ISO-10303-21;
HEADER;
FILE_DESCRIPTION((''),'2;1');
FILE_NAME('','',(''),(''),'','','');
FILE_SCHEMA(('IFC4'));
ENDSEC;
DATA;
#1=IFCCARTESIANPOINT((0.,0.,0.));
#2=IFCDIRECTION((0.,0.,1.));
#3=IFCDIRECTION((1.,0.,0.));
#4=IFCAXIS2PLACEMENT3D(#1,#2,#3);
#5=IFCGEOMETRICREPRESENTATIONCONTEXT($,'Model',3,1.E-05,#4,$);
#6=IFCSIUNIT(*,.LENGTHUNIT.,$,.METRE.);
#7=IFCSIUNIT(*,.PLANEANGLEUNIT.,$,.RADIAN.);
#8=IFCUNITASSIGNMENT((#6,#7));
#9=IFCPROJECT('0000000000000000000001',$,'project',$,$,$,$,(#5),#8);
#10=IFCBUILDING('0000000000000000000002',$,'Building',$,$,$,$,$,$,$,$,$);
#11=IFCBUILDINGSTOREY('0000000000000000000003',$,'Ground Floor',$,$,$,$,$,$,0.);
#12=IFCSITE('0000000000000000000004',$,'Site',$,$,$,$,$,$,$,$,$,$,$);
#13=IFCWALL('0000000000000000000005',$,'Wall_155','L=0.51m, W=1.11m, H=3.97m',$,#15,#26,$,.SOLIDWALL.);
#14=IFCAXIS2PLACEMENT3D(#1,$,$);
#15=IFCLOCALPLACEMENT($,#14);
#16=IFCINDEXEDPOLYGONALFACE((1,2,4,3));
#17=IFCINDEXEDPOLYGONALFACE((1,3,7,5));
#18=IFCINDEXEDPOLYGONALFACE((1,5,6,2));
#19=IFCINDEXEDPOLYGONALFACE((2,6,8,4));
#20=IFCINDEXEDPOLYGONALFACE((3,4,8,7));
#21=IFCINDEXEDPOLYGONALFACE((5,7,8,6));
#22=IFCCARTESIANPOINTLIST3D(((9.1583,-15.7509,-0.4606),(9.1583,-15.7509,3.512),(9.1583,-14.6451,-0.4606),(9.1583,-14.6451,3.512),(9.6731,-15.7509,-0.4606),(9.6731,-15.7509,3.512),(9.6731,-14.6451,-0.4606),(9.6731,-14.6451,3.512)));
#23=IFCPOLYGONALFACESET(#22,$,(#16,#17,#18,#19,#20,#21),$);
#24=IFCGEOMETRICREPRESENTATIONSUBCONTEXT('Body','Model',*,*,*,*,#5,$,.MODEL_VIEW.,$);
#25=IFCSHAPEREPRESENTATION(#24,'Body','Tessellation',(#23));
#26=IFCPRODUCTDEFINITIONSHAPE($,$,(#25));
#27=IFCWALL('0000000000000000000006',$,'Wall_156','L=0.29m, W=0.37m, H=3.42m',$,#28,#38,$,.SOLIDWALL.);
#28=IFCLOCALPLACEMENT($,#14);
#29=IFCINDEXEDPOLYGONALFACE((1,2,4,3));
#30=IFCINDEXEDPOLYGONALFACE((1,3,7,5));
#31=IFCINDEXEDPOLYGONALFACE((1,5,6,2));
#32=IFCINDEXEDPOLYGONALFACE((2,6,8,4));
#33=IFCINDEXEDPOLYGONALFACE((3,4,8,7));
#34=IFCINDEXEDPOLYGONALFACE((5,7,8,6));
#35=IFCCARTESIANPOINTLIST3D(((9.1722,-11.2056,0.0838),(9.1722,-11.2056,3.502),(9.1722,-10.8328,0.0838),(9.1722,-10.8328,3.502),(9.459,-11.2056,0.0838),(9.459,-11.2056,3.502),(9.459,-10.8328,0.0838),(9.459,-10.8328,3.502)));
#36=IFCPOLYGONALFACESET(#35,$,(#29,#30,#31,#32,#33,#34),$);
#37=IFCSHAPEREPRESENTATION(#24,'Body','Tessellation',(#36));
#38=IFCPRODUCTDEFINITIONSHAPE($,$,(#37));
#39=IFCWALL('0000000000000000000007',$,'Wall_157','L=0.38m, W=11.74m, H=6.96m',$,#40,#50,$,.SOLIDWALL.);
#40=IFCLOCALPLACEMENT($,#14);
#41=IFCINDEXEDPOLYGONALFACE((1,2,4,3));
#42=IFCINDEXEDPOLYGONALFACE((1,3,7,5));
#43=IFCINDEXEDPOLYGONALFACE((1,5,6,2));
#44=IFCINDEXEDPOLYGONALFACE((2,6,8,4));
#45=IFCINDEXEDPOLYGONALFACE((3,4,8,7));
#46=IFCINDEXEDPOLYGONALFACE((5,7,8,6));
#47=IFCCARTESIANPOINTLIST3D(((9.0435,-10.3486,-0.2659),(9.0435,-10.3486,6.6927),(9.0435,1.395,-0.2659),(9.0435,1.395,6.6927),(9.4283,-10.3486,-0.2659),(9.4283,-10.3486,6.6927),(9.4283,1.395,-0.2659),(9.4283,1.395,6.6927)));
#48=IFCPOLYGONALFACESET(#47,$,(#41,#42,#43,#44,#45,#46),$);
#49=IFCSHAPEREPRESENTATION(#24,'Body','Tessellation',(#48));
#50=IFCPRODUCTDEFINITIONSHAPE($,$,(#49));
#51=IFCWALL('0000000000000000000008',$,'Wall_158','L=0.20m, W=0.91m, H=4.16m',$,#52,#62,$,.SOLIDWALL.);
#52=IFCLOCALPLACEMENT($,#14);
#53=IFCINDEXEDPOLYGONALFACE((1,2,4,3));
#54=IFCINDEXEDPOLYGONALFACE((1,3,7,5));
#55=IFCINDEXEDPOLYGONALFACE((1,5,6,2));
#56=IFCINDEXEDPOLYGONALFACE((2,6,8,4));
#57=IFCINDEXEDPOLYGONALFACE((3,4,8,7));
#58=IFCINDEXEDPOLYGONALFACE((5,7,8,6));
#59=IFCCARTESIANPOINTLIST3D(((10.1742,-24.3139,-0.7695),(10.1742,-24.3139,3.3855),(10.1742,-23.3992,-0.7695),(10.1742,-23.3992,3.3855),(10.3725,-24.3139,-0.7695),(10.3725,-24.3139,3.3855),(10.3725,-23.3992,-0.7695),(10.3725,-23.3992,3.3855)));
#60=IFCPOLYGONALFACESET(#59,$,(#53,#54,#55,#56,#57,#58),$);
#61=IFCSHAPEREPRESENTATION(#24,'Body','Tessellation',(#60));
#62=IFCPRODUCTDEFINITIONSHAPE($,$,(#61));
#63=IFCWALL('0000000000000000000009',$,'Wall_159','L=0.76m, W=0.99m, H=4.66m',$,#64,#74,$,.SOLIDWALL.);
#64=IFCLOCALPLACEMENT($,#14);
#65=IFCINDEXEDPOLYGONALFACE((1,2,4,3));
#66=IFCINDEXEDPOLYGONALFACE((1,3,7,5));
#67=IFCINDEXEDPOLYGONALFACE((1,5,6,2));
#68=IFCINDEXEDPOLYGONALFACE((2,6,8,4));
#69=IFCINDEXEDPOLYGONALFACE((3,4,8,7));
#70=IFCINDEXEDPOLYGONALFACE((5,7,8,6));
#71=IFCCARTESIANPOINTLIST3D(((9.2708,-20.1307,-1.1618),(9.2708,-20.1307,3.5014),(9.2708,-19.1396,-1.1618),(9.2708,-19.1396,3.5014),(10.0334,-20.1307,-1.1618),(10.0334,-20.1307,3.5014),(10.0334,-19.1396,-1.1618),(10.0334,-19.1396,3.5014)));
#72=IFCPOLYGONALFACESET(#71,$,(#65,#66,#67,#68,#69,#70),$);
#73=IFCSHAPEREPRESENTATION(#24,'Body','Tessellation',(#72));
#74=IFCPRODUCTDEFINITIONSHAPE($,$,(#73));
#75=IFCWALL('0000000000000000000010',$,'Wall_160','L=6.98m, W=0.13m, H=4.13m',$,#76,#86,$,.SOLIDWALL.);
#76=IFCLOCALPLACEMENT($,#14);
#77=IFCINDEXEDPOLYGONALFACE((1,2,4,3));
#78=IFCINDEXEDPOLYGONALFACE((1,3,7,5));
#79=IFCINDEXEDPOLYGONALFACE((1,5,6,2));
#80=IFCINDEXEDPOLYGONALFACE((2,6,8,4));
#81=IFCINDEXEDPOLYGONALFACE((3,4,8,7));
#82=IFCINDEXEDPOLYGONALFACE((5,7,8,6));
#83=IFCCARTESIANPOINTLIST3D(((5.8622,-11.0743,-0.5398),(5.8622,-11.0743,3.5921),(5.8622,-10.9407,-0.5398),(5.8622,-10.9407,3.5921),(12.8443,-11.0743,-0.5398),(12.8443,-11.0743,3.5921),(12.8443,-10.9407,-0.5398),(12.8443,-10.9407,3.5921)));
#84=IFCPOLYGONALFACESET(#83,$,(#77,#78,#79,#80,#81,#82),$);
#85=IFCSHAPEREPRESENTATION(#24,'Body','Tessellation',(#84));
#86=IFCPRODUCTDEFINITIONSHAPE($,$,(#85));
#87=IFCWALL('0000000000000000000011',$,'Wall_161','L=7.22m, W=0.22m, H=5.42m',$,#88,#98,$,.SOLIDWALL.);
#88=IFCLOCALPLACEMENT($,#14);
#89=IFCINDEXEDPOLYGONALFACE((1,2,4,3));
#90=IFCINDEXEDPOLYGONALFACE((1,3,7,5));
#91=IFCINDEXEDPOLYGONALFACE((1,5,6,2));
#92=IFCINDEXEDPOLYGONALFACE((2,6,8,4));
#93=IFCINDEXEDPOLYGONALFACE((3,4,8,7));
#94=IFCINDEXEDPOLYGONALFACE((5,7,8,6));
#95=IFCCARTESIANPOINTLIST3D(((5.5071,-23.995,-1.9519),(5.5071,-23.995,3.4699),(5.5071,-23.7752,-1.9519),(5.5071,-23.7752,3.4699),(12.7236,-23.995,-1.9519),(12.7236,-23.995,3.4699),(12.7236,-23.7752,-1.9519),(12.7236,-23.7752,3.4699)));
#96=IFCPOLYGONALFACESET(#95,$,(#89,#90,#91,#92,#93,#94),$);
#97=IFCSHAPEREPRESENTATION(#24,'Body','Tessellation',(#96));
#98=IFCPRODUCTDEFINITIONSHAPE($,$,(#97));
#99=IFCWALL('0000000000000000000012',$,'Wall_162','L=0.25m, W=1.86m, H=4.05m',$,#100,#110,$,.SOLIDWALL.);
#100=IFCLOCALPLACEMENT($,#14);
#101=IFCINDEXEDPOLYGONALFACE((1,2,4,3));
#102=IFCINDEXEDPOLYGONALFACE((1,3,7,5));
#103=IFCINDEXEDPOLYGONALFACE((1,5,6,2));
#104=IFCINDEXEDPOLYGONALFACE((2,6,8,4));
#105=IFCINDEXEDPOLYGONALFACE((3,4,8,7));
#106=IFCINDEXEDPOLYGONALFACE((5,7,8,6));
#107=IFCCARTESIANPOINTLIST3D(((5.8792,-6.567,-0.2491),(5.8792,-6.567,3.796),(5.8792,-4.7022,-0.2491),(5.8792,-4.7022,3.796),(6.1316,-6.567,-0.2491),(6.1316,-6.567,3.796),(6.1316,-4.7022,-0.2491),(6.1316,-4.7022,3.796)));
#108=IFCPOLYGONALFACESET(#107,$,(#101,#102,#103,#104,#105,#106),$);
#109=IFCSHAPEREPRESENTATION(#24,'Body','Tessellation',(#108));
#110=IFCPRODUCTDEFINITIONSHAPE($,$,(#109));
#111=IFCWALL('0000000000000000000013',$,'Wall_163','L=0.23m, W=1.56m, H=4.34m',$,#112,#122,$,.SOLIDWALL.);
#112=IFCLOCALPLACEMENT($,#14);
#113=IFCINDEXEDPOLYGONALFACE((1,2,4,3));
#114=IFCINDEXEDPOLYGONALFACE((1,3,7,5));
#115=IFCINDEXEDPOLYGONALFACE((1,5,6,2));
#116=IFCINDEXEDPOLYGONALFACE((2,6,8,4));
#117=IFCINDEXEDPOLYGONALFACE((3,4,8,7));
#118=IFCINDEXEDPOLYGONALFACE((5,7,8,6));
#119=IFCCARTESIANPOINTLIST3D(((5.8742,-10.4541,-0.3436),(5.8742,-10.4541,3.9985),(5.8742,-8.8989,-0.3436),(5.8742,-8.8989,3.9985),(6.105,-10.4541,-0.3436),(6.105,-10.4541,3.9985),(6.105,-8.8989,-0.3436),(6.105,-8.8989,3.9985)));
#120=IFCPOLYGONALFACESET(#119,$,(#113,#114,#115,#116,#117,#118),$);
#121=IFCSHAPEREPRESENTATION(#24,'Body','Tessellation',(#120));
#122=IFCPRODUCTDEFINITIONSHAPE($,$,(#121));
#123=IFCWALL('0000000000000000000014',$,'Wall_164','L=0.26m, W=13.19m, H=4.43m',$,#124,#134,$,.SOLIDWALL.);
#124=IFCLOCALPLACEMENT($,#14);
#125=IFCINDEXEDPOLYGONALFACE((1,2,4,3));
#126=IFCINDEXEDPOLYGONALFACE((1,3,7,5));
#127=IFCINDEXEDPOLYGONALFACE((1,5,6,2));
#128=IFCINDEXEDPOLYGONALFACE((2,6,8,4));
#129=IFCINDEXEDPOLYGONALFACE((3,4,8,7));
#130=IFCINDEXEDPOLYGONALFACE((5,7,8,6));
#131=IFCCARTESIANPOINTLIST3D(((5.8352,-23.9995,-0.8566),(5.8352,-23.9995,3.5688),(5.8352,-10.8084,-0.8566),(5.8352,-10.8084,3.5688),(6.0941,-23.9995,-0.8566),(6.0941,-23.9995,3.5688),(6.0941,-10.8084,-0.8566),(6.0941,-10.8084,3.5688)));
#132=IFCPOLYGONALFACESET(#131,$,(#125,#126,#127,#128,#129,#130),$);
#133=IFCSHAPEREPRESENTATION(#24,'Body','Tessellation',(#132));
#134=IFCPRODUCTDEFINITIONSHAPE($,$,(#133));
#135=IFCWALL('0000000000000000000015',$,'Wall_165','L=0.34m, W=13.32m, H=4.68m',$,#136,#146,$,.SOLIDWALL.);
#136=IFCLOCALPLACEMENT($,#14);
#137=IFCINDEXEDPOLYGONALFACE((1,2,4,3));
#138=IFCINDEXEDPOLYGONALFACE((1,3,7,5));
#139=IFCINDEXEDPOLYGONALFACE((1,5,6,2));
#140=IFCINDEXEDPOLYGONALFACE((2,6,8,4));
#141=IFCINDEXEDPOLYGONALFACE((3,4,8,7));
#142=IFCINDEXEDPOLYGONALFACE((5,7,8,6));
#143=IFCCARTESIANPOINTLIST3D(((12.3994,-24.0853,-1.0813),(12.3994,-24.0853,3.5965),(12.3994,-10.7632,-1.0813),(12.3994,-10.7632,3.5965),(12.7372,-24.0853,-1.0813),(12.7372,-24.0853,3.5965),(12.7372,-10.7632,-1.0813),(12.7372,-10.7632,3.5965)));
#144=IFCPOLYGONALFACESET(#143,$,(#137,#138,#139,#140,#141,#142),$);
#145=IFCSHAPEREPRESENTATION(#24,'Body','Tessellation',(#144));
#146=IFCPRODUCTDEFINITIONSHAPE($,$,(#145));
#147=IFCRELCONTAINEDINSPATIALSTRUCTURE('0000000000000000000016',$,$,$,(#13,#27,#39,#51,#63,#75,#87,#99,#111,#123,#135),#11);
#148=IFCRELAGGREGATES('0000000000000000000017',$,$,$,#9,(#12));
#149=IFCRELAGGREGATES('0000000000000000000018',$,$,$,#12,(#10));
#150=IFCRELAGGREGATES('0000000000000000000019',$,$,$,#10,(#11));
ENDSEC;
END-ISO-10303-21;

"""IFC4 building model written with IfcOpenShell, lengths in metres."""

from ifc_helpers import new_model, si_unit, frame, origin_with_axes, origin_2d, context, subcontext, project, spatial, rectangle, extrude, element, save


model = new_model("IFC4")

# Units and contexts
model_context = context("Model", 3, precision=1e-05, world=origin_with_axes())
body_context = subcontext(model_context, "Body", "Model", "MODEL_VIEW")
ifc_project = project(units=[si_unit("LENGTHUNIT", "METRE"), si_unit("PLANEANGLEUNIT", "RADIAN")], contexts=[model_context])

# Site, building, storey
site = spatial("IfcSite", under=ifc_project, Name="Site")
building = spatial("IfcBuilding", under=site, Name="Building")
storey = spatial("IfcBuildingStorey", under=building, Name="Ground Floor", Elevation=0.0)

# Walls
element("IfcWall", 1, inside=storey, Name="Wall_155", Description="L=0.51m, W=1.11m, H=3.97m", PredefinedType="SOLIDWALL", context=body_context, shape_type="SweptSolid", body=[
    extrude(rectangle(XDim=0.5147, YDim=1.1058, at=origin_2d()), frame((9.4157, -15.198, -0.4606), z_axis=(0.0, 0.0, 1.0), x_axis=(1.0, 0.0, 0.0)), (0.0, 0.0, 1.0), 3.9726),
])
element("IfcWall", 2, inside=storey, Name="Wall_156", Description="L=0.29m, W=0.37m, H=3.42m", PredefinedType="SOLIDWALL", context=body_context, shape_type="SweptSolid", body=[
    extrude(rectangle(XDim=0.2869, YDim=0.3728, at=origin_2d()), frame((9.3156, -11.0192, 0.0838), z_axis=(0.0, 0.0, 1.0), x_axis=(1.0, 0.0, 0.0)), (0.0, 0.0, 1.0), 3.4182),
])
element("IfcWall", 3, inside=storey, Name="Wall_157", Description="L=0.38m, W=11.74m, H=6.96m", PredefinedType="SOLIDWALL", context=body_context, shape_type="SweptSolid", body=[
    extrude(rectangle(XDim=0.3848, YDim=11.7436, at=origin_2d()), frame((9.2359, -4.4768, -0.2659), z_axis=(0.0, 0.0, 1.0), x_axis=(1.0, 0.0, 0.0)), (0.0, 0.0, 1.0), 6.9586),
])
element("IfcWall", 4, inside=storey, Name="Wall_158", Description="L=0.20m, W=0.91m, H=4.16m", PredefinedType="SOLIDWALL", context=body_context, shape_type="SweptSolid", body=[
    extrude(rectangle(XDim=0.1983, YDim=0.9148, at=origin_2d()), frame((10.2733, -23.8565, -0.7695), z_axis=(0.0, 0.0, 1.0), x_axis=(1.0, 0.0, 0.0)), (0.0, 0.0, 1.0), 4.155),
])
element("IfcWall", 5, inside=storey, Name="Wall_159", Description="L=0.76m, W=0.99m, H=4.66m", PredefinedType="SOLIDWALL", context=body_context, shape_type="SweptSolid", body=[
    extrude(rectangle(XDim=0.7626, YDim=0.9911, at=origin_2d()), frame((9.6521, -19.6352, -1.1618), z_axis=(0.0, 0.0, 1.0), x_axis=(1.0, 0.0, 0.0)), (0.0, 0.0, 1.0), 4.6632),
])
element("IfcWall", 6, inside=storey, Name="Wall_160", Description="L=6.98m, W=0.13m, H=4.13m", PredefinedType="SOLIDWALL", context=body_context, shape_type="SweptSolid", body=[
    extrude(rectangle(XDim=6.9821, YDim=0.1337, at=origin_2d()), frame((9.3532, -11.0075, -0.5398), z_axis=(0.0, 0.0, 1.0), x_axis=(1.0, 0.0, 0.0)), (0.0, 0.0, 1.0), 4.132),
])
element("IfcWall", 7, inside=storey, Name="Wall_161", Description="L=7.22m, W=0.22m, H=5.42m", PredefinedType="SOLIDWALL", context=body_context, shape_type="SweptSolid", body=[
    extrude(rectangle(XDim=7.2165, YDim=0.2198, at=origin_2d()), frame((9.1153, -23.8851, -1.9519), z_axis=(0.0, 0.0, 1.0), x_axis=(1.0, 0.0, 0.0)), (0.0, 0.0, 1.0), 5.4218),
])
element("IfcWall", 8, inside=storey, Name="Wall_162", Description="L=0.25m, W=1.86m, H=4.05m", PredefinedType="SOLIDWALL", context=body_context, shape_type="SweptSolid", body=[
    extrude(rectangle(XDim=0.2524, YDim=1.8648, at=origin_2d()), frame((6.0054, -5.6346, -0.2491), z_axis=(0.0, 0.0, 1.0), x_axis=(1.0, 0.0, 0.0)), (0.0, 0.0, 1.0), 4.045),
])
element("IfcWall", 9, inside=storey, Name="Wall_163", Description="L=0.23m, W=1.56m, H=4.34m", PredefinedType="SOLIDWALL", context=body_context, shape_type="SweptSolid", body=[
    extrude(rectangle(XDim=0.2308, YDim=1.5552, at=origin_2d()), frame((5.9896, -9.6765, -0.3436), z_axis=(0.0, 0.0, 1.0), x_axis=(1.0, 0.0, 0.0)), (0.0, 0.0, 1.0), 4.3422),
])
element("IfcWall", 10, inside=storey, Name="Wall_164", Description="L=0.26m, W=13.19m, H=4.43m", PredefinedType="SOLIDWALL", context=body_context, shape_type="SweptSolid", body=[
    extrude(rectangle(XDim=0.2589, YDim=13.191, at=origin_2d()), frame((5.9647, -17.4039, -0.8566), z_axis=(0.0, 0.0, 1.0), x_axis=(1.0, 0.0, 0.0)), (0.0, 0.0, 1.0), 4.4254),
])
element("IfcWall", 11, inside=storey, Name="Wall_165", Description="L=0.34m, W=13.32m, H=4.68m", PredefinedType="SOLIDWALL", context=body_context, shape_type="SweptSolid", body=[
    extrude(rectangle(XDim=0.3377, YDim=13.3221, at=origin_2d()), frame((12.5683, -17.4243, -1.0813), z_axis=(0.0, 0.0, 1.0), x_axis=(1.0, 0.0, 0.0)), (0.0, 0.0, 1.0), 4.6778),
])

save(model, "model.ifc")
